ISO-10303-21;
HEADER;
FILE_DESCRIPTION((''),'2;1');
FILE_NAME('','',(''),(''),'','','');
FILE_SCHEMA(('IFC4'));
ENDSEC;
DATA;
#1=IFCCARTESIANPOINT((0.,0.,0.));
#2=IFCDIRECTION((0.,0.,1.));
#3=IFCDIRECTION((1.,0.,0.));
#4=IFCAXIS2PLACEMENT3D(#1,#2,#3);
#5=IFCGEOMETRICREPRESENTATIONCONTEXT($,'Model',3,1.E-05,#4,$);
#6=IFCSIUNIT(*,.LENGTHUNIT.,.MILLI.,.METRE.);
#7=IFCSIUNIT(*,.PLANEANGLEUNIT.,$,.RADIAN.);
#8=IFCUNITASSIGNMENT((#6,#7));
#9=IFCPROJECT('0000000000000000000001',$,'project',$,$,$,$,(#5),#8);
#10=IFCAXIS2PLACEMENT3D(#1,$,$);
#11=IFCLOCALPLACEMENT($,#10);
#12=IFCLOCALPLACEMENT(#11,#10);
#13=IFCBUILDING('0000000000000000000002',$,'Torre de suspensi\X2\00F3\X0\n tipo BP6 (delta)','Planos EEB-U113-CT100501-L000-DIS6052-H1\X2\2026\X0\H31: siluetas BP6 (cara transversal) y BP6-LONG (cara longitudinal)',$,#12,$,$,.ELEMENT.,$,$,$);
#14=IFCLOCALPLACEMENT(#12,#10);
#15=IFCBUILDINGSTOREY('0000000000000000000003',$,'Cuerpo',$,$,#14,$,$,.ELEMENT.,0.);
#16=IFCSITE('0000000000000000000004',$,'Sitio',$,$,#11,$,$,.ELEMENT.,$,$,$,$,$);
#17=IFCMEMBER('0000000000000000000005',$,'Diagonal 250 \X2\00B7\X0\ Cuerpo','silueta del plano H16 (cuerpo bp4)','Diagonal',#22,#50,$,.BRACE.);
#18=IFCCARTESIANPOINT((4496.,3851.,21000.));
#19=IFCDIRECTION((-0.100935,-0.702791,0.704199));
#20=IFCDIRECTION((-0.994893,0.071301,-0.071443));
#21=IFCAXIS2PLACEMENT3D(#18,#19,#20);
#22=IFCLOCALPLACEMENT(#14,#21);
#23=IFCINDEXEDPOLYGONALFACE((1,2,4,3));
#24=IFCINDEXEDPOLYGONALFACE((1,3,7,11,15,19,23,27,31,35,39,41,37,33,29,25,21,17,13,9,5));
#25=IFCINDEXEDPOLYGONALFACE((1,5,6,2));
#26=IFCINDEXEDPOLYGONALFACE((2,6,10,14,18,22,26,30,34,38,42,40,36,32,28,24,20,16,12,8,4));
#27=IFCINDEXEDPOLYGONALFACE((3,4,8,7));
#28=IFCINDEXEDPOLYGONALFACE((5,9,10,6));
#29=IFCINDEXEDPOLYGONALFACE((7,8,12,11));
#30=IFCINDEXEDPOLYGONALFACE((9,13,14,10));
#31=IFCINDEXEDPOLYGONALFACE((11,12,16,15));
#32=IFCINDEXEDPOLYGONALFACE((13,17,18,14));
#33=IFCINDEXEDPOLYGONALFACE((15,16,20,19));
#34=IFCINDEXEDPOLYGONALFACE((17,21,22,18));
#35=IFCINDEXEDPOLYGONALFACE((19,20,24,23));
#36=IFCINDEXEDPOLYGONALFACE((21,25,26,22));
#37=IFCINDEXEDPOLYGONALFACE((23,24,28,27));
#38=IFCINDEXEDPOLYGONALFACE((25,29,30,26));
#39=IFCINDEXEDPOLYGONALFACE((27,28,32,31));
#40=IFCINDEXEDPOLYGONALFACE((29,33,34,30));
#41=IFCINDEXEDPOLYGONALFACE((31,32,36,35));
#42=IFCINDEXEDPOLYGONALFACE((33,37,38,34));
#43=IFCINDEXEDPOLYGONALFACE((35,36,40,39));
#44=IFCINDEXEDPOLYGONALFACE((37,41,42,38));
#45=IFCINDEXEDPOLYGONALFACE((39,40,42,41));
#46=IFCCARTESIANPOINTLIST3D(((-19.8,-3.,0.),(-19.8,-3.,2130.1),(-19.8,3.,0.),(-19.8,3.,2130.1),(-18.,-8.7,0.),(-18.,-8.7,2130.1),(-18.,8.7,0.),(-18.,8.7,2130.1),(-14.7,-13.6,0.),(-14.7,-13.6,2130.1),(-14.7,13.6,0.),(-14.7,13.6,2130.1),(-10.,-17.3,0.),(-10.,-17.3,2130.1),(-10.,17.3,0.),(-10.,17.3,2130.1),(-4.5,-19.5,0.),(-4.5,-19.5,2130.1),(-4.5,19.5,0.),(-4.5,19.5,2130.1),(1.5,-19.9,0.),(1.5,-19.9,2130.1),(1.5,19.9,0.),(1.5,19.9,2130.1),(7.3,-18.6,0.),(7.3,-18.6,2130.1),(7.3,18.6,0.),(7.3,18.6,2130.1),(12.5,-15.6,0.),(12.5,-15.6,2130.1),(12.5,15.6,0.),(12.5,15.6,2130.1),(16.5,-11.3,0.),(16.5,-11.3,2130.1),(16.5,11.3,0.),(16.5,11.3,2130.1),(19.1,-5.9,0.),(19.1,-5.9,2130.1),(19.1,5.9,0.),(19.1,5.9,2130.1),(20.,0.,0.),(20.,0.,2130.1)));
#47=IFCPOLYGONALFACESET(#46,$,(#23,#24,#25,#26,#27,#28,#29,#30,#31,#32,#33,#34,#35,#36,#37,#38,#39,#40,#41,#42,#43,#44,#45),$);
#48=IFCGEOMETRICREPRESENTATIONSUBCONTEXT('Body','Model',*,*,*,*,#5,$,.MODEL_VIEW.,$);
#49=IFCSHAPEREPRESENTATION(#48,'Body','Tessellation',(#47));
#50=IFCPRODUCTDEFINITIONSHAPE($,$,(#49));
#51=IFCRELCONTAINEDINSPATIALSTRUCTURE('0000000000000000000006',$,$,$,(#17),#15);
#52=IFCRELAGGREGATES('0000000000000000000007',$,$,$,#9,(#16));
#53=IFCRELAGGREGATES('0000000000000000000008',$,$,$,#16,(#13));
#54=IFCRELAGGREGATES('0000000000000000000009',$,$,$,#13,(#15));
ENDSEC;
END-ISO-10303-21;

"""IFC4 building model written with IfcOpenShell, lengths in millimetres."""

from ifc_helpers import new_model, si_unit, frame, origin, origin_with_axes, place, context, subcontext, project, spatial, circle, extrude, element, save


model = new_model("IFC4")

# Units and contexts
model_context = context("Model", 3, precision=1e-05, world=origin_with_axes())
body_context = subcontext(model_context, "Body", "Model", "MODEL_VIEW")
ifc_project = project(units=[si_unit("LENGTHUNIT", "METRE", prefix="MILLI"), si_unit("PLANEANGLEUNIT", "RADIAN")], contexts=[model_context])

# Site, building, storey
site_placement = place(None, origin())
site = spatial("IfcSite", under=ifc_project, at=site_placement, Name="Sitio", CompositionType="ELEMENT")
building_placement = place(site_placement, origin())
building = spatial("IfcBuilding", under=site, at=building_placement, Name="Torre de suspensión tipo BP6 (delta)", Description="Planos EEB-U113-CT100501-L000-DIS6052-H1…H31: siluetas BP6 (cara transversal) y BP6-LONG (cara longitudinal)", CompositionType="ELEMENT")
storey_placement = place(building_placement, origin())
storey = spatial("IfcBuildingStorey", under=building, at=storey_placement, Name="Cuerpo", CompositionType="ELEMENT", Elevation=0.0)

# Member
member_1_placement = place(storey_placement, frame((4496.0, 3851.0, 21000.0), z_axis=(-0.100935, -0.702791, 0.704199), x_axis=(-0.994893, 0.071301, -0.071443)))
element("IfcMember", 1, at=member_1_placement, inside=storey, Name="Diagonal 250 · Cuerpo", Description="silueta del plano H16 (cuerpo bp4)", ObjectType="Diagonal", PredefinedType="BRACE", context=body_context, shape_type="SweptSolid", body=[
    extrude(circle(Radius=20.0), None, (0.0, 0.0, 1.0), 2130.1),
])

save(model, "model.ifc")
